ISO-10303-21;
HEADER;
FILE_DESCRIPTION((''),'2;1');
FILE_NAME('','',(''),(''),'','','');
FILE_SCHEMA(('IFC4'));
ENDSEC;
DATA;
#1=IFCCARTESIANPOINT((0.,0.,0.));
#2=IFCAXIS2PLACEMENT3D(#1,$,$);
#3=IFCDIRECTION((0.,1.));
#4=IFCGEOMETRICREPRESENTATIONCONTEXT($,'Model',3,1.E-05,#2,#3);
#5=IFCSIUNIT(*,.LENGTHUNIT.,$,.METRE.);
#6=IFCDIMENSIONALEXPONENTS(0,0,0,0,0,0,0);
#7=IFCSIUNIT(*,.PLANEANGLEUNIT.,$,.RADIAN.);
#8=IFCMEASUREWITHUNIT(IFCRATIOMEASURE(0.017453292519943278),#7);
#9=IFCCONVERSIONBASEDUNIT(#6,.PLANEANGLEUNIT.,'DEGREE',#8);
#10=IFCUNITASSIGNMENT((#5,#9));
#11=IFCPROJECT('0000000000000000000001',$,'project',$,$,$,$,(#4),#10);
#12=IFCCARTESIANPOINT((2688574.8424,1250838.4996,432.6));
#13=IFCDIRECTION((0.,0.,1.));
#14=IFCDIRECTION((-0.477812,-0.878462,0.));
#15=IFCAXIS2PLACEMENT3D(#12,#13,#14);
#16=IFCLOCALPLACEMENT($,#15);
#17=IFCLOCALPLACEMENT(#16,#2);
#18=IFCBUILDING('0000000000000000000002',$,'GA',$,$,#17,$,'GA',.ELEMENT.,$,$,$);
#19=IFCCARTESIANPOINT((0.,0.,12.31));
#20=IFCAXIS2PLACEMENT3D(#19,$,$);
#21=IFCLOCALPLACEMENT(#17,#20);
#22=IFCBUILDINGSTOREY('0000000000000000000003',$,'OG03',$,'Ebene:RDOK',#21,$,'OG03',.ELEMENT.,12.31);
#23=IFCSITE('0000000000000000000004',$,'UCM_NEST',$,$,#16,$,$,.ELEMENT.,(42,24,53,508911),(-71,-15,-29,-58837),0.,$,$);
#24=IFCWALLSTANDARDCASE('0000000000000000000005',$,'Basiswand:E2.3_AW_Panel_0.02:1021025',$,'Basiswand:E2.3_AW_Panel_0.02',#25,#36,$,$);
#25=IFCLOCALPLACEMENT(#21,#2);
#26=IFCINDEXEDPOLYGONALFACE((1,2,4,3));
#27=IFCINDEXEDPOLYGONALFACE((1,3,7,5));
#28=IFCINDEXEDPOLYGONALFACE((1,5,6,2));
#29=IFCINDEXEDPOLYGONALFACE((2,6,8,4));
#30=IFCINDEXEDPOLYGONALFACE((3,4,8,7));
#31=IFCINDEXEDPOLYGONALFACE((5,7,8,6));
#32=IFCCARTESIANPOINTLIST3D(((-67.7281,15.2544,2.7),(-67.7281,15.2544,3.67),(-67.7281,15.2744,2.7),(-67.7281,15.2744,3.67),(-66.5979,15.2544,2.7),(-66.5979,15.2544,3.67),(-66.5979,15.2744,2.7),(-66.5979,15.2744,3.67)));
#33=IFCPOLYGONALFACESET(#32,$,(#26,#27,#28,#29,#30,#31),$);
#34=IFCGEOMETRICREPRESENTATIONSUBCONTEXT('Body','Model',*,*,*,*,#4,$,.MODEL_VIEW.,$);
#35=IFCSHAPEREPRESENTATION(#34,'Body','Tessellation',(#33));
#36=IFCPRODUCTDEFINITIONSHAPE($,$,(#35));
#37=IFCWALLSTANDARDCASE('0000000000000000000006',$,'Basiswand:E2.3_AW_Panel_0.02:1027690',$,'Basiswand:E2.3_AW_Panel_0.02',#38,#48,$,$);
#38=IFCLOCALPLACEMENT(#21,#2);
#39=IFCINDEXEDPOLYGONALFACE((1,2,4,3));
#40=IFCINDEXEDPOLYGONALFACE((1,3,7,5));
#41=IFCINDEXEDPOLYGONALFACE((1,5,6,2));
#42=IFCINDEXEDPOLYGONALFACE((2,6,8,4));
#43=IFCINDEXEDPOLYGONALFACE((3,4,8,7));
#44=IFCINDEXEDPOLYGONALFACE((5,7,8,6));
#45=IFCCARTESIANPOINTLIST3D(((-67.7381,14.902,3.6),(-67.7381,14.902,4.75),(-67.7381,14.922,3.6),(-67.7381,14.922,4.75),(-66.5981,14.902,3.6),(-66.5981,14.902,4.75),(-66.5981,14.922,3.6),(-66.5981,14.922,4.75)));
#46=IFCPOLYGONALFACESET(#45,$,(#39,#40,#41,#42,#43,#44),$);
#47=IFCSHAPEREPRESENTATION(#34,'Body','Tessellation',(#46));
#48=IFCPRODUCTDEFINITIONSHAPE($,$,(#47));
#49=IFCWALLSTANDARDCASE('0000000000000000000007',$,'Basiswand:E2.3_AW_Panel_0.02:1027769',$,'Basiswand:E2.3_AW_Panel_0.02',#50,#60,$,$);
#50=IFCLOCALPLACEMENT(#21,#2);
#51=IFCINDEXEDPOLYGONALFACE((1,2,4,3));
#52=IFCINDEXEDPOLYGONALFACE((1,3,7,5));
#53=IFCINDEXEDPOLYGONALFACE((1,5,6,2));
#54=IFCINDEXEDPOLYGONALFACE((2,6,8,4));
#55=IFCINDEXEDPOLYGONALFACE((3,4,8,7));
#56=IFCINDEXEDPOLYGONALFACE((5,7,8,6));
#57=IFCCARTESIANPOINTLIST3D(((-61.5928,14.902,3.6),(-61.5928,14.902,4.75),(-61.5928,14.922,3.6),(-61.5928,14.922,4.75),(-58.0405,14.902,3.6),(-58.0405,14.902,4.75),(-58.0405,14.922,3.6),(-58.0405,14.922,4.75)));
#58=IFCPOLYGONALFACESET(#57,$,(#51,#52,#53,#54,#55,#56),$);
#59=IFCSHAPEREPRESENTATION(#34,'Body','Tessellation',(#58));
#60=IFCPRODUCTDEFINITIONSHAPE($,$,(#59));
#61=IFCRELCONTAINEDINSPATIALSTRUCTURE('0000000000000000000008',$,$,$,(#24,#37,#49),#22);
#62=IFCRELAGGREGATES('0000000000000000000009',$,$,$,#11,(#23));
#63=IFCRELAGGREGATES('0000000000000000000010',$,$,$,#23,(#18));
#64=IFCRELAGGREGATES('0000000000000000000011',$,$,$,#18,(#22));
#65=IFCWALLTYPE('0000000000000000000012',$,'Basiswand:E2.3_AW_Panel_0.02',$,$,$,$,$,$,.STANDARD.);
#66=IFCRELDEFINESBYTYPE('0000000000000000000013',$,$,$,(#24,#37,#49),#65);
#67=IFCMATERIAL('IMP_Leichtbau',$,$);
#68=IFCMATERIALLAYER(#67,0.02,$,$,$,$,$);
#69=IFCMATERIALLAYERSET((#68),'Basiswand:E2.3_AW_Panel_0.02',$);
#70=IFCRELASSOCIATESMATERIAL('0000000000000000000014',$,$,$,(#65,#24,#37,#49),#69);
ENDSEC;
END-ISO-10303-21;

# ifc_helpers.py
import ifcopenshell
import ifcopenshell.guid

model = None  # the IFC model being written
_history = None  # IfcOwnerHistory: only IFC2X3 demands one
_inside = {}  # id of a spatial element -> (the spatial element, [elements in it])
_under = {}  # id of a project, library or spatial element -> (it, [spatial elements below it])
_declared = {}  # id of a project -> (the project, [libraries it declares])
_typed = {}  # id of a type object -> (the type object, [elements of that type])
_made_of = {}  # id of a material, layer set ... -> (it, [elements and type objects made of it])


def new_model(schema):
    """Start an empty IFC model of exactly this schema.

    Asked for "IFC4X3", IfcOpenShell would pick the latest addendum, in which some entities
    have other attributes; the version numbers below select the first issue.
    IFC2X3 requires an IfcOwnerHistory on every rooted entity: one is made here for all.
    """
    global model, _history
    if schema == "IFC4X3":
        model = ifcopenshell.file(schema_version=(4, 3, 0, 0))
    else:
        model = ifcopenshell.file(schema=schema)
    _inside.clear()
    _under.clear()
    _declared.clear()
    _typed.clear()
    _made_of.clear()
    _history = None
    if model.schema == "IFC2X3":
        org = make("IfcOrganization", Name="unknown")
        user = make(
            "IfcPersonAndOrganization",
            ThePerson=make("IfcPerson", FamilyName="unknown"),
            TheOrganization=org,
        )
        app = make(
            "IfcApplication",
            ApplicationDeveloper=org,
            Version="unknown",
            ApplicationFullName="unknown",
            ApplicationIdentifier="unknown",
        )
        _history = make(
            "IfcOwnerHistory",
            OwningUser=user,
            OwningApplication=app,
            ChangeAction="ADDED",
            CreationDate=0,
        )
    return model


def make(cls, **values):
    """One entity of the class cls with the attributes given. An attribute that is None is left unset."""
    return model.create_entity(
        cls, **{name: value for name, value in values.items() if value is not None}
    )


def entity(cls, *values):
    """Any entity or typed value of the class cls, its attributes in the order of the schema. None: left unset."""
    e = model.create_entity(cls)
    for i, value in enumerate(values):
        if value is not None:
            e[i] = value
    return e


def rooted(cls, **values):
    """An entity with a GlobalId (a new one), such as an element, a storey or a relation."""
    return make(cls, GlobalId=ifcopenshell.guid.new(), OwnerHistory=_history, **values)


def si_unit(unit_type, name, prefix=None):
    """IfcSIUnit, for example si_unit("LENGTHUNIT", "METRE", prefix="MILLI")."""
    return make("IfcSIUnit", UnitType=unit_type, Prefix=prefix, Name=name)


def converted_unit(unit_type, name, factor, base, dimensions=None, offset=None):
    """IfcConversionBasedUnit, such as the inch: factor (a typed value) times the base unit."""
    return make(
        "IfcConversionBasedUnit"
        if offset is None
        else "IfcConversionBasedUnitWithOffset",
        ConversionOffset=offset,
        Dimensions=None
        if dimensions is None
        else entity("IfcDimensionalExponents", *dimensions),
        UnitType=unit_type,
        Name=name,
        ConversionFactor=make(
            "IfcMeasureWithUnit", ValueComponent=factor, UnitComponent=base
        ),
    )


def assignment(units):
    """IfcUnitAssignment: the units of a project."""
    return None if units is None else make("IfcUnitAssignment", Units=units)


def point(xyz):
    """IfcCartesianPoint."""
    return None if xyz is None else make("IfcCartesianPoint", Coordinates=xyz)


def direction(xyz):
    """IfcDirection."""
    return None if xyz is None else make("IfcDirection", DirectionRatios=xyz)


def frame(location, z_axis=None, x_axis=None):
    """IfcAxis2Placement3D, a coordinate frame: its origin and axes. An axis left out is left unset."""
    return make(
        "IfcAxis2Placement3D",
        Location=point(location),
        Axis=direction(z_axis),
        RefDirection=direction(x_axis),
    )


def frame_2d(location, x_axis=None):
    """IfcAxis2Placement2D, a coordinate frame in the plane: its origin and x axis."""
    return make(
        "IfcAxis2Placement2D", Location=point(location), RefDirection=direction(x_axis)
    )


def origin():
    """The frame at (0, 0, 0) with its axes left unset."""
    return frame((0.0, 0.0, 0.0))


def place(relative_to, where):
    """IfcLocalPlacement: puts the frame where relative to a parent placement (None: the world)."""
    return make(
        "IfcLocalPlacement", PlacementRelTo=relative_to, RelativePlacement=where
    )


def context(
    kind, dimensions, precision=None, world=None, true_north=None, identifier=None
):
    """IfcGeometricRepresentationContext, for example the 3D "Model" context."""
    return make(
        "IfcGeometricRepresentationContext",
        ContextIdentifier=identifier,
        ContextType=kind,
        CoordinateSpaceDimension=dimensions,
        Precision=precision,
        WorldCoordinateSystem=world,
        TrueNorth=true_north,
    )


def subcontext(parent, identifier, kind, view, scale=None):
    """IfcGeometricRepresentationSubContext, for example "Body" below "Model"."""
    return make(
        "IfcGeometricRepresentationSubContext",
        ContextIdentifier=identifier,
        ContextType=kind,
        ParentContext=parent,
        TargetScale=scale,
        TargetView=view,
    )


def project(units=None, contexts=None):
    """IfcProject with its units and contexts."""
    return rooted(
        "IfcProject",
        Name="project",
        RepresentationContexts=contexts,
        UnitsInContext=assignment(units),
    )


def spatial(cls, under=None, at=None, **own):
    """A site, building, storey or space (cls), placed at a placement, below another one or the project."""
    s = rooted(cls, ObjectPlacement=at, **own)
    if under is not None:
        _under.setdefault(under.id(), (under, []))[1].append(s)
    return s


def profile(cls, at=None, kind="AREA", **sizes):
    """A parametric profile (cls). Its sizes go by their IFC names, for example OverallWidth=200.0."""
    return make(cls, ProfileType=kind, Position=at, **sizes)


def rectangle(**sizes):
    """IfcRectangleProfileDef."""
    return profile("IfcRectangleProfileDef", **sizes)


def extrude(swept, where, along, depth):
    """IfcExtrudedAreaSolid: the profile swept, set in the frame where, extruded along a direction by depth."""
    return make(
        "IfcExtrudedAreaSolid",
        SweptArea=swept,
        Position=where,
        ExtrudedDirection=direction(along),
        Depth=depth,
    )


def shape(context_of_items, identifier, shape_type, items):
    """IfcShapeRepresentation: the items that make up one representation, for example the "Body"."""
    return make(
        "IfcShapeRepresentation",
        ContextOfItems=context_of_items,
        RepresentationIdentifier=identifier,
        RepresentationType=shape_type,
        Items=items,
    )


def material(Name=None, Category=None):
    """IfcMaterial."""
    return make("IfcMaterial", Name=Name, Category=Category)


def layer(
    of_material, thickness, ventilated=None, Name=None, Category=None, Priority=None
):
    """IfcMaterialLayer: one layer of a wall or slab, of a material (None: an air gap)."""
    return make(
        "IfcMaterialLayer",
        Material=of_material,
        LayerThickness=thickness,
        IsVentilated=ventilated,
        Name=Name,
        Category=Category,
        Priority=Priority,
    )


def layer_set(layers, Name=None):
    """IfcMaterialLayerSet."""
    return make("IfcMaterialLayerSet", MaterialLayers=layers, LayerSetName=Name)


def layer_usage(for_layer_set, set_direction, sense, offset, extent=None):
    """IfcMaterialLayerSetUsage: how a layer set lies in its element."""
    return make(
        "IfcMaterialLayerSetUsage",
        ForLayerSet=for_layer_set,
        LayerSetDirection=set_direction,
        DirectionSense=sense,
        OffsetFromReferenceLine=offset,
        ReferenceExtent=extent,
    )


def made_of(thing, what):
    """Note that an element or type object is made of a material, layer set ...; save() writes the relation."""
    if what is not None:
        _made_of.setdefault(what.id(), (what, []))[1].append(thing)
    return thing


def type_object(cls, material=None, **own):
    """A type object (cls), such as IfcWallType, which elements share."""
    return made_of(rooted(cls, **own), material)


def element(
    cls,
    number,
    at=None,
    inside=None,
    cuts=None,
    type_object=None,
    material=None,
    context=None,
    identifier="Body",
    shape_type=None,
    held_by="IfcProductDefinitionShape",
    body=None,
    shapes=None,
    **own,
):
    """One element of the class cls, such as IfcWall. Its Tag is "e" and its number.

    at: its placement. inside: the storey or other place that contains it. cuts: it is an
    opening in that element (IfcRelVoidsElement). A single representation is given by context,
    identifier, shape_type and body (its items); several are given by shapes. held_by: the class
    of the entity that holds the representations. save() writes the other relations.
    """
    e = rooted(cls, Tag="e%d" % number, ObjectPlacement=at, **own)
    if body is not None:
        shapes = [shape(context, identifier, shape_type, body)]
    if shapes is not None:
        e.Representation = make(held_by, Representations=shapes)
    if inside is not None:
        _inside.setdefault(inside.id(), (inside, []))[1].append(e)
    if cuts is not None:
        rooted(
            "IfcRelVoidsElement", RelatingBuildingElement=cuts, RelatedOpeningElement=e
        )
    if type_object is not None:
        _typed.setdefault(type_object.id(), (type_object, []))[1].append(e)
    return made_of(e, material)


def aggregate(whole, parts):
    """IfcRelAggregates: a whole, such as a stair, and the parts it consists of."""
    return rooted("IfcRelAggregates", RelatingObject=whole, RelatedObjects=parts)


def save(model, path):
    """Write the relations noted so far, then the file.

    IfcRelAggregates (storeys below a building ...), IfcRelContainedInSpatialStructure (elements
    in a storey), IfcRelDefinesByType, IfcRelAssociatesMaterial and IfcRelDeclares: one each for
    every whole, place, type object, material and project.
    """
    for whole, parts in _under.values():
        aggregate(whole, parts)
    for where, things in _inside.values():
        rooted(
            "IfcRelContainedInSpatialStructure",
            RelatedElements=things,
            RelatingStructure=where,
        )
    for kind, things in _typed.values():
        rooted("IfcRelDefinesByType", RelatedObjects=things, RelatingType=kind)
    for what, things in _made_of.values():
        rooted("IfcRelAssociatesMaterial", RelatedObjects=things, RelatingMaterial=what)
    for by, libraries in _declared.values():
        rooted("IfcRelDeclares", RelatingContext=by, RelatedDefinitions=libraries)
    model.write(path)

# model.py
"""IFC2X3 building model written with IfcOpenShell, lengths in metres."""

from ifc_helpers import new_model, entity, si_unit, converted_unit, direction, frame, frame_2d, origin, place, context, subcontext, project, spatial, rectangle, extrude, material, layer, layer_set, layer_usage, type_object, element, save


model = new_model("IFC2X3")

# Units and contexts
model_context = context("Model", 3, precision=1e-05, world=origin(), true_north=direction((0.0, 1.0)))
body_context = subcontext(model_context, "Body", "Model", "MODEL_VIEW")
ifc_project = project(units=[si_unit("LENGTHUNIT", "METRE"), converted_unit("PLANEANGLEUNIT", "DEGREE", entity("IfcRatioMeasure", 0.017453292519943278), si_unit("PLANEANGLEUNIT", "RADIAN"), dimensions=[0, 0, 0, 0, 0, 0, 0])], contexts=[model_context])

# Site, building, storey
site_placement = place(None, frame((2688574.8424, 1250838.4996, 432.6), z_axis=(0.0, 0.0, 1.0), x_axis=(-0.477812, -0.878462, 0.0)))
site = spatial("IfcSite", under=ifc_project, at=site_placement, Name="UCM_NEST", CompositionType="ELEMENT", RefLatitude=(42, 24, 53, 508911), RefLongitude=(-71, -15, -29, -58837), RefElevation=0.0)
building_placement = place(site_placement, origin())
building = spatial("IfcBuilding", under=site, at=building_placement, Name="GA", LongName="GA", CompositionType="ELEMENT")
storey_placement = place(building_placement, frame((0.0, 0.0, 12.31)))
storey = spatial("IfcBuildingStorey", under=building, at=storey_placement, Name="OG03", ObjectType="Ebene:RDOK", LongName="OG03", CompositionType="ELEMENT", Elevation=12.31)

# Walls
ifc_material_1 = material(Name="IMP_Leichtbau")
ifc_layer_1 = layer(ifc_material_1, 0.02)
ifc_layer_set_1 = layer_set([ifc_layer_1], Name="Basiswand:E2.3_AW_Panel_0.02")
ifc_layer_usage_1 = layer_usage(ifc_layer_set_1, "AXIS2", "NEGATIVE", 0.01)
wall_type_1 = type_object("IfcWallType", Name="Basiswand:E2.3_AW_Panel_0.02", PredefinedType="STANDARD", material=ifc_layer_set_1)
wall_1_placement = place(storey_placement, frame((-66.5979, 15.2644, 2.7), z_axis=(0.0, 0.0, 1.0), x_axis=(-1.0, 0.0, 0.0)))
element("IfcWallStandardCase", 1, at=wall_1_placement, inside=storey, type_object=wall_type_1, material=ifc_layer_usage_1, Name="Basiswand:E2.3_AW_Panel_0.02:1021025", ObjectType="Basiswand:E2.3_AW_Panel_0.02", context=body_context, shape_type="SweptSolid", body=[
    extrude(rectangle(XDim=1.1302, YDim=0.02, at=frame_2d((0.5651, 0.0), x_axis=(-1.0, 0.0))), origin(), (0.0, 0.0, 1.0), 0.97),
])
wall_2_placement = place(storey_placement, frame((-67.7381, 14.912, 3.6)))
element("IfcWallStandardCase", 2, at=wall_2_placement, inside=storey, type_object=wall_type_1, material=ifc_layer_usage_1, Name="Basiswand:E2.3_AW_Panel_0.02:1027690", ObjectType="Basiswand:E2.3_AW_Panel_0.02", context=body_context, shape_type="SweptSolid", body=[
    extrude(rectangle(XDim=1.14, YDim=0.02, at=frame_2d((0.57, 0.0), x_axis=(-1.0, 0.0))), origin(), (0.0, 0.0, 1.0), 1.15),
])
wall_3_placement = place(storey_placement, frame((-61.5928, 14.912, 3.6)))
element("IfcWallStandardCase", 3, at=wall_3_placement, inside=storey, type_object=wall_type_1, material=ifc_layer_usage_1, Name="Basiswand:E2.3_AW_Panel_0.02:1027769", ObjectType="Basiswand:E2.3_AW_Panel_0.02", context=body_context, shape_type="SweptSolid", body=[
    extrude(rectangle(XDim=3.5523, YDim=0.02, at=frame_2d((1.7761, 0.0), x_axis=(-1.0, 0.0))), origin(), (0.0, 0.0, 1.0), 1.15),
])

save(model, "model.ifc")
